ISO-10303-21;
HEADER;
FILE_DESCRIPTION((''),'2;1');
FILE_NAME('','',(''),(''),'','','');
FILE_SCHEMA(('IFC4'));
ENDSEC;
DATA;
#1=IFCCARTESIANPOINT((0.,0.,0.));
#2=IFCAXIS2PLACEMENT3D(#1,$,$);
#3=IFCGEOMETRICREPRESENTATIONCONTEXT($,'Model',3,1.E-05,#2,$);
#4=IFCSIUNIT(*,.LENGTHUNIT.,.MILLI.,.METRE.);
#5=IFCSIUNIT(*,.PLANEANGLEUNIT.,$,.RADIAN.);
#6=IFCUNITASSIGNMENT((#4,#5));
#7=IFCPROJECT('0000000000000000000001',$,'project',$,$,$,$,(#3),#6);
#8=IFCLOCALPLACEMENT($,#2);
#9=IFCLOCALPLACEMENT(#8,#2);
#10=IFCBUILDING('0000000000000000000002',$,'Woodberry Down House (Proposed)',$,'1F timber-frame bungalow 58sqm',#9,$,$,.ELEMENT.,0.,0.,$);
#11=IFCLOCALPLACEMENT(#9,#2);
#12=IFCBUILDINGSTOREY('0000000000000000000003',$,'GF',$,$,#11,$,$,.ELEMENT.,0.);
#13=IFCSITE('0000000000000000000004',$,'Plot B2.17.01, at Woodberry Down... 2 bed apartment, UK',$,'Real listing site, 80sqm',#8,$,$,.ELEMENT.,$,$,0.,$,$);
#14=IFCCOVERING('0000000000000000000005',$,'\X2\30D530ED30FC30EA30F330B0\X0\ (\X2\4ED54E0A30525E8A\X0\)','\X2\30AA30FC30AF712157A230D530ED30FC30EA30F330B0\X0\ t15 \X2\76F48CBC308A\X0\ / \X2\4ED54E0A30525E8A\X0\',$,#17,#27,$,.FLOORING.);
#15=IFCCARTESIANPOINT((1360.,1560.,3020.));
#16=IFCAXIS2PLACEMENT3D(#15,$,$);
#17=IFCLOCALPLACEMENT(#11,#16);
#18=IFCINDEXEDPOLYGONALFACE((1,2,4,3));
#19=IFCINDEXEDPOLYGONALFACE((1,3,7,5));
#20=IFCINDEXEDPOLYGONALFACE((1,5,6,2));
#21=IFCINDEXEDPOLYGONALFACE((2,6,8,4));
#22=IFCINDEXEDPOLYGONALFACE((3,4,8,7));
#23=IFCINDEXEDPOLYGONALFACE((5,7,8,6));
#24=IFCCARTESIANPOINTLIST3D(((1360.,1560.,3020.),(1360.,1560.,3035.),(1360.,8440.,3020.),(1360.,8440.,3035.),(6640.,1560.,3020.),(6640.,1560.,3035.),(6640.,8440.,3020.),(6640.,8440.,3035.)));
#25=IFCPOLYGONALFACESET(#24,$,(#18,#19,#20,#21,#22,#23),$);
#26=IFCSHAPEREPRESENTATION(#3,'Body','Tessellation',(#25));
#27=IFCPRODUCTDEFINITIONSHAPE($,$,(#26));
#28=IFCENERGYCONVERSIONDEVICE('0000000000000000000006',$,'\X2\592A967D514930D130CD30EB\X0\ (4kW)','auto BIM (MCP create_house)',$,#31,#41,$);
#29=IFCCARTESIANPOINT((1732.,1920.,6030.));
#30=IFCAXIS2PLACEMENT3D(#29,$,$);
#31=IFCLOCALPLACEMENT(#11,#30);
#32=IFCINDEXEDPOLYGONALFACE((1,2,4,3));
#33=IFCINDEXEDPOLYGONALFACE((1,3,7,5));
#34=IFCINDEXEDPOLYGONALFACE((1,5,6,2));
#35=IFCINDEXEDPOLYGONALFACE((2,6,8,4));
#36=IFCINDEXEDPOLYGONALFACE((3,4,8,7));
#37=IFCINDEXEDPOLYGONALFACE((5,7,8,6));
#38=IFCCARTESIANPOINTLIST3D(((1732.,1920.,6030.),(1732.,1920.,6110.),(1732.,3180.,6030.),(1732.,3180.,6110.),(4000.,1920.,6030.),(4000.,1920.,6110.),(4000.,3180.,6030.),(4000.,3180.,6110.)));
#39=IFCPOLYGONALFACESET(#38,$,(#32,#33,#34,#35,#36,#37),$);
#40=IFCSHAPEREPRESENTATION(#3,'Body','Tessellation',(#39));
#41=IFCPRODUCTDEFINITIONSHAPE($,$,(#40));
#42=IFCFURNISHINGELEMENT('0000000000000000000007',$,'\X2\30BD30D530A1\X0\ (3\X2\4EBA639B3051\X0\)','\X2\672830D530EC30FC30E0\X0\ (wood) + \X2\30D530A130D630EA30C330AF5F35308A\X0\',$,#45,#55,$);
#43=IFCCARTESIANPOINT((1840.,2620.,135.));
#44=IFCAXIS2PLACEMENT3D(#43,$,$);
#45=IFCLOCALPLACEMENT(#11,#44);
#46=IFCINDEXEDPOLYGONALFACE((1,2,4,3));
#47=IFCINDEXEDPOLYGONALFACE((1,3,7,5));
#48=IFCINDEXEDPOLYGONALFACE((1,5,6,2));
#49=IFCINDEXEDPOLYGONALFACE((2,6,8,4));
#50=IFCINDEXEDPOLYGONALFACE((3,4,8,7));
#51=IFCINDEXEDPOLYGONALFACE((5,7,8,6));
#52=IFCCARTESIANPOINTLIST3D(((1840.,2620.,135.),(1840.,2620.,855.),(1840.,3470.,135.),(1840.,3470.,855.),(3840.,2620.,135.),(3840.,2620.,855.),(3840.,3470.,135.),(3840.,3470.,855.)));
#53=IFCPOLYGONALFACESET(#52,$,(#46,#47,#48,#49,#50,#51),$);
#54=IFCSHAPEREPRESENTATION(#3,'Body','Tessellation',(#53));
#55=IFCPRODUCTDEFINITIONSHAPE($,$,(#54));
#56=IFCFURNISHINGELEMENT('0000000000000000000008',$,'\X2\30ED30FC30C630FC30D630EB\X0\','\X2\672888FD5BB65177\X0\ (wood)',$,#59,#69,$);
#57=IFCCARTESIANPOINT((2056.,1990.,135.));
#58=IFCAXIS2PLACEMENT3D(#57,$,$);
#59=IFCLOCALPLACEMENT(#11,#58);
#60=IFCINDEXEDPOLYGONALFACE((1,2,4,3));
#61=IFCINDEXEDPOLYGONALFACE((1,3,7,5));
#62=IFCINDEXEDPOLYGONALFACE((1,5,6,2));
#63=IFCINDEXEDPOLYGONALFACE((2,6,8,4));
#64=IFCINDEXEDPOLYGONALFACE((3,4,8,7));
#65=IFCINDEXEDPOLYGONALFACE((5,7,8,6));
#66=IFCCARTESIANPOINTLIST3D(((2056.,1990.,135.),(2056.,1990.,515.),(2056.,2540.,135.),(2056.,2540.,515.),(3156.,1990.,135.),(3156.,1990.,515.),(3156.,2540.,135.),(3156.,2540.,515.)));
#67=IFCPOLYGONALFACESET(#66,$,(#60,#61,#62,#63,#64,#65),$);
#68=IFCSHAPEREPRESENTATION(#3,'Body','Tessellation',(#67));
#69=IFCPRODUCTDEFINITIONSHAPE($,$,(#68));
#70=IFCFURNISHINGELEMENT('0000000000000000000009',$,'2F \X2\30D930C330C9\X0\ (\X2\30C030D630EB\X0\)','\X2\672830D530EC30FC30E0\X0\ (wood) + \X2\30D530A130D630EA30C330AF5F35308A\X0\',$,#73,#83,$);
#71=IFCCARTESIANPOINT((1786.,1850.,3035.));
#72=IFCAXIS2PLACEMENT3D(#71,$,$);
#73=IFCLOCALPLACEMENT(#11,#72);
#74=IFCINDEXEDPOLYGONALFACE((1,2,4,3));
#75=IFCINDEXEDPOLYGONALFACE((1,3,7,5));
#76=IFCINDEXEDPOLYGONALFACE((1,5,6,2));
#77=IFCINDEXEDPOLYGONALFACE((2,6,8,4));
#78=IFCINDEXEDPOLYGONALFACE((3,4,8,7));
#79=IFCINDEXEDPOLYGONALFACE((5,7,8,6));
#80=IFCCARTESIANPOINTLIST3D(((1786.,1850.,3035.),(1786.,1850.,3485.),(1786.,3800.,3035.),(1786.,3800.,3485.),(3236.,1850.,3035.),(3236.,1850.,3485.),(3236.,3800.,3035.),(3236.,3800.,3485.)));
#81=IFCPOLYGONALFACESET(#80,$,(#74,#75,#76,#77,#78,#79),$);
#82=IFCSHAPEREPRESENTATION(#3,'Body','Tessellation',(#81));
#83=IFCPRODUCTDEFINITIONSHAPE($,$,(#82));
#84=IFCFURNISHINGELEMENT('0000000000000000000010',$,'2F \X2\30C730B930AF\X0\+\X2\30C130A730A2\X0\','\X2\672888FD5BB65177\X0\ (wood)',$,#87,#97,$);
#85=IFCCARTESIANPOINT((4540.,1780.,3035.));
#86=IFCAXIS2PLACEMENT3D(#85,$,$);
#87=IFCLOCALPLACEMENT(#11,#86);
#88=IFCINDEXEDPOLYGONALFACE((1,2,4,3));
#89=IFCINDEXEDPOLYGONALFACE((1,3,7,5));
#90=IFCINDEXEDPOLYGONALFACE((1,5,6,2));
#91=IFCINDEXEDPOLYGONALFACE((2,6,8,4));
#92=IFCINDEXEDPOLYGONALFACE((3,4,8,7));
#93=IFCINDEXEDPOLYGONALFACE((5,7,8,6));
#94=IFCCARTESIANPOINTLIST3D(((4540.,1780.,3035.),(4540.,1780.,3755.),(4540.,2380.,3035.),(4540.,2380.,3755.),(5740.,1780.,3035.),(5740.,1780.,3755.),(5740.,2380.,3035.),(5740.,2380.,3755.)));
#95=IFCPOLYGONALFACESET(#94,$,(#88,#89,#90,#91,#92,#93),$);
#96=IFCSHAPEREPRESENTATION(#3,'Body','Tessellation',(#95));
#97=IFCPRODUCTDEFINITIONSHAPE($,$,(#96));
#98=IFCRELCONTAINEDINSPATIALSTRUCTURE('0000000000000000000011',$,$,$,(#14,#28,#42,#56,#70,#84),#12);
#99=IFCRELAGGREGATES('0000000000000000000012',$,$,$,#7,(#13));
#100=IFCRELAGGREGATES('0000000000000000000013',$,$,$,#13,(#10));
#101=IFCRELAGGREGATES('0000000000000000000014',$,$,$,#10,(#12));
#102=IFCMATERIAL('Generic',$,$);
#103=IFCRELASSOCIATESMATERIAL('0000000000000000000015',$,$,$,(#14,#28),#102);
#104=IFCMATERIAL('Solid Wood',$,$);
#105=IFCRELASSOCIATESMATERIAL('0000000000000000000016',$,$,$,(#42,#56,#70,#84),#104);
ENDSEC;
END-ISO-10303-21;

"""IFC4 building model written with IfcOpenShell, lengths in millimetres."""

from ifc_helpers import new_model, si_unit, frame, frame_2d, origin, place, context, project, spatial, rectangle, extrude, material, element, save


model = new_model("IFC4")

# Units and contexts
model_context = context("Model", 3, precision=1e-05, world=origin())
ifc_project = project(units=[si_unit("LENGTHUNIT", "METRE", prefix="MILLI"), si_unit("PLANEANGLEUNIT", "RADIAN")], contexts=[model_context])

# Site, building, storey
site_placement = place(None, origin())
site = spatial("IfcSite", under=ifc_project, at=site_placement, Name="Plot B2.17.01, at Woodberry Down... 2 bed apartment, UK", ObjectType="Real listing site, 80sqm", CompositionType="ELEMENT", RefElevation=0.0)
building_placement = place(site_placement, origin())
building = spatial("IfcBuilding", under=site, at=building_placement, Name="Woodberry Down House (Proposed)", ObjectType="1F timber-frame bungalow 58sqm", CompositionType="ELEMENT", ElevationOfRefHeight=0.0, ElevationOfTerrain=0.0)
storey_placement = place(building_placement, origin())
storey = spatial("IfcBuildingStorey", under=building, at=storey_placement, Name="GF", CompositionType="ELEMENT", Elevation=0.0)

# Shared definitions
ifc_material_1 = material(Name="Solid Wood")

# Shared definitions
ifc_material_2 = material(Name="Generic")

# Covering
covering_placement = place(storey_placement, frame((1360.0, 1560.0, 3020.0)))
element("IfcCovering", 1, at=covering_placement, inside=storey, material=ifc_material_2, Name="フローリング (仕上げ床)", Description="オーク無垢フローリング t15 直貼り / 仕上げ床", PredefinedType="FLOORING", context=model_context, shape_type="SweptSolid", body=[
    extrude(rectangle(XDim=5280.0, YDim=6880.0, at=frame_2d((2640.0, 3440.0))), frame((1360.0, 1560.0, 3020.0)), (0.0, 0.0, 1.0), 15.0),
])

# Energy conversion device
energy_conversion_device_placement = place(storey_placement, frame((1732.0, 1920.0, 6030.0)))
element("IfcEnergyConversionDevice", 2, at=energy_conversion_device_placement, inside=storey, material=ifc_material_2, Name="太陽光パネル (4kW)", Description="auto BIM (MCP create_house)", context=model_context, shape_type="SweptSolid", body=[
    extrude(rectangle(XDim=2268.0, YDim=1260.0, at=frame_2d((1134.0, 630.0))), frame((1732.0, 1920.0, 6030.0)), (0.0, 0.0, 1.0), 80.0),
])

# Furnishing elements
furnishing_1_placement = place(storey_placement, frame((1840.0, 2620.0, 135.0)))
element("IfcFurnishingElement", 3, at=furnishing_1_placement, inside=storey, material=ifc_material_1, Name="ソファ (3人掛け)", Description="木フレーム (wood) + ファブリック張り", context=model_context, shape_type="SweptSolid", body=[
    extrude(rectangle(XDim=2000.0, YDim=850.0, at=frame_2d((1000.0, 425.0))), frame((1840.0, 2620.0, 135.0)), (0.0, 0.0, 1.0), 720.0),
])
furnishing_2_placement = place(storey_placement, frame((2056.0, 1990.0, 135.0)))
element("IfcFurnishingElement", 4, at=furnishing_2_placement, inside=storey, material=ifc_material_1, Name="ローテーブル", Description="木製家具 (wood)", context=model_context, shape_type="SweptSolid", body=[
    extrude(rectangle(XDim=1100.0, YDim=550.0, at=frame_2d((550.0, 275.0))), frame((2056.0, 1990.0, 135.0)), (0.0, 0.0, 1.0), 380.0),
])
furnishing_3_placement = place(storey_placement, frame((1786.0, 1850.0, 3035.0)))
element("IfcFurnishingElement", 5, at=furnishing_3_placement, inside=storey, material=ifc_material_1, Name="2F ベッド (ダブル)", Description="木フレーム (wood) + ファブリック張り", context=model_context, shape_type="SweptSolid", body=[
    extrude(rectangle(XDim=1450.0, YDim=1950.0, at=frame_2d((725.0, 975.0))), frame((1786.0, 1850.0, 3035.0)), (0.0, 0.0, 1.0), 450.0),
])
furnishing_4_placement = place(storey_placement, frame((4540.0, 1780.0, 3035.0)))
element("IfcFurnishingElement", 6, at=furnishing_4_placement, inside=storey, material=ifc_material_1, Name="2F デスク+チェア", Description="木製家具 (wood)", context=model_context, shape_type="SweptSolid", body=[
    extrude(rectangle(XDim=1200.0, YDim=600.0, at=frame_2d((600.0, 300.0))), frame((4540.0, 1780.0, 3035.0)), (0.0, 0.0, 1.0), 720.0),
])

save(model, "model.ifc")
